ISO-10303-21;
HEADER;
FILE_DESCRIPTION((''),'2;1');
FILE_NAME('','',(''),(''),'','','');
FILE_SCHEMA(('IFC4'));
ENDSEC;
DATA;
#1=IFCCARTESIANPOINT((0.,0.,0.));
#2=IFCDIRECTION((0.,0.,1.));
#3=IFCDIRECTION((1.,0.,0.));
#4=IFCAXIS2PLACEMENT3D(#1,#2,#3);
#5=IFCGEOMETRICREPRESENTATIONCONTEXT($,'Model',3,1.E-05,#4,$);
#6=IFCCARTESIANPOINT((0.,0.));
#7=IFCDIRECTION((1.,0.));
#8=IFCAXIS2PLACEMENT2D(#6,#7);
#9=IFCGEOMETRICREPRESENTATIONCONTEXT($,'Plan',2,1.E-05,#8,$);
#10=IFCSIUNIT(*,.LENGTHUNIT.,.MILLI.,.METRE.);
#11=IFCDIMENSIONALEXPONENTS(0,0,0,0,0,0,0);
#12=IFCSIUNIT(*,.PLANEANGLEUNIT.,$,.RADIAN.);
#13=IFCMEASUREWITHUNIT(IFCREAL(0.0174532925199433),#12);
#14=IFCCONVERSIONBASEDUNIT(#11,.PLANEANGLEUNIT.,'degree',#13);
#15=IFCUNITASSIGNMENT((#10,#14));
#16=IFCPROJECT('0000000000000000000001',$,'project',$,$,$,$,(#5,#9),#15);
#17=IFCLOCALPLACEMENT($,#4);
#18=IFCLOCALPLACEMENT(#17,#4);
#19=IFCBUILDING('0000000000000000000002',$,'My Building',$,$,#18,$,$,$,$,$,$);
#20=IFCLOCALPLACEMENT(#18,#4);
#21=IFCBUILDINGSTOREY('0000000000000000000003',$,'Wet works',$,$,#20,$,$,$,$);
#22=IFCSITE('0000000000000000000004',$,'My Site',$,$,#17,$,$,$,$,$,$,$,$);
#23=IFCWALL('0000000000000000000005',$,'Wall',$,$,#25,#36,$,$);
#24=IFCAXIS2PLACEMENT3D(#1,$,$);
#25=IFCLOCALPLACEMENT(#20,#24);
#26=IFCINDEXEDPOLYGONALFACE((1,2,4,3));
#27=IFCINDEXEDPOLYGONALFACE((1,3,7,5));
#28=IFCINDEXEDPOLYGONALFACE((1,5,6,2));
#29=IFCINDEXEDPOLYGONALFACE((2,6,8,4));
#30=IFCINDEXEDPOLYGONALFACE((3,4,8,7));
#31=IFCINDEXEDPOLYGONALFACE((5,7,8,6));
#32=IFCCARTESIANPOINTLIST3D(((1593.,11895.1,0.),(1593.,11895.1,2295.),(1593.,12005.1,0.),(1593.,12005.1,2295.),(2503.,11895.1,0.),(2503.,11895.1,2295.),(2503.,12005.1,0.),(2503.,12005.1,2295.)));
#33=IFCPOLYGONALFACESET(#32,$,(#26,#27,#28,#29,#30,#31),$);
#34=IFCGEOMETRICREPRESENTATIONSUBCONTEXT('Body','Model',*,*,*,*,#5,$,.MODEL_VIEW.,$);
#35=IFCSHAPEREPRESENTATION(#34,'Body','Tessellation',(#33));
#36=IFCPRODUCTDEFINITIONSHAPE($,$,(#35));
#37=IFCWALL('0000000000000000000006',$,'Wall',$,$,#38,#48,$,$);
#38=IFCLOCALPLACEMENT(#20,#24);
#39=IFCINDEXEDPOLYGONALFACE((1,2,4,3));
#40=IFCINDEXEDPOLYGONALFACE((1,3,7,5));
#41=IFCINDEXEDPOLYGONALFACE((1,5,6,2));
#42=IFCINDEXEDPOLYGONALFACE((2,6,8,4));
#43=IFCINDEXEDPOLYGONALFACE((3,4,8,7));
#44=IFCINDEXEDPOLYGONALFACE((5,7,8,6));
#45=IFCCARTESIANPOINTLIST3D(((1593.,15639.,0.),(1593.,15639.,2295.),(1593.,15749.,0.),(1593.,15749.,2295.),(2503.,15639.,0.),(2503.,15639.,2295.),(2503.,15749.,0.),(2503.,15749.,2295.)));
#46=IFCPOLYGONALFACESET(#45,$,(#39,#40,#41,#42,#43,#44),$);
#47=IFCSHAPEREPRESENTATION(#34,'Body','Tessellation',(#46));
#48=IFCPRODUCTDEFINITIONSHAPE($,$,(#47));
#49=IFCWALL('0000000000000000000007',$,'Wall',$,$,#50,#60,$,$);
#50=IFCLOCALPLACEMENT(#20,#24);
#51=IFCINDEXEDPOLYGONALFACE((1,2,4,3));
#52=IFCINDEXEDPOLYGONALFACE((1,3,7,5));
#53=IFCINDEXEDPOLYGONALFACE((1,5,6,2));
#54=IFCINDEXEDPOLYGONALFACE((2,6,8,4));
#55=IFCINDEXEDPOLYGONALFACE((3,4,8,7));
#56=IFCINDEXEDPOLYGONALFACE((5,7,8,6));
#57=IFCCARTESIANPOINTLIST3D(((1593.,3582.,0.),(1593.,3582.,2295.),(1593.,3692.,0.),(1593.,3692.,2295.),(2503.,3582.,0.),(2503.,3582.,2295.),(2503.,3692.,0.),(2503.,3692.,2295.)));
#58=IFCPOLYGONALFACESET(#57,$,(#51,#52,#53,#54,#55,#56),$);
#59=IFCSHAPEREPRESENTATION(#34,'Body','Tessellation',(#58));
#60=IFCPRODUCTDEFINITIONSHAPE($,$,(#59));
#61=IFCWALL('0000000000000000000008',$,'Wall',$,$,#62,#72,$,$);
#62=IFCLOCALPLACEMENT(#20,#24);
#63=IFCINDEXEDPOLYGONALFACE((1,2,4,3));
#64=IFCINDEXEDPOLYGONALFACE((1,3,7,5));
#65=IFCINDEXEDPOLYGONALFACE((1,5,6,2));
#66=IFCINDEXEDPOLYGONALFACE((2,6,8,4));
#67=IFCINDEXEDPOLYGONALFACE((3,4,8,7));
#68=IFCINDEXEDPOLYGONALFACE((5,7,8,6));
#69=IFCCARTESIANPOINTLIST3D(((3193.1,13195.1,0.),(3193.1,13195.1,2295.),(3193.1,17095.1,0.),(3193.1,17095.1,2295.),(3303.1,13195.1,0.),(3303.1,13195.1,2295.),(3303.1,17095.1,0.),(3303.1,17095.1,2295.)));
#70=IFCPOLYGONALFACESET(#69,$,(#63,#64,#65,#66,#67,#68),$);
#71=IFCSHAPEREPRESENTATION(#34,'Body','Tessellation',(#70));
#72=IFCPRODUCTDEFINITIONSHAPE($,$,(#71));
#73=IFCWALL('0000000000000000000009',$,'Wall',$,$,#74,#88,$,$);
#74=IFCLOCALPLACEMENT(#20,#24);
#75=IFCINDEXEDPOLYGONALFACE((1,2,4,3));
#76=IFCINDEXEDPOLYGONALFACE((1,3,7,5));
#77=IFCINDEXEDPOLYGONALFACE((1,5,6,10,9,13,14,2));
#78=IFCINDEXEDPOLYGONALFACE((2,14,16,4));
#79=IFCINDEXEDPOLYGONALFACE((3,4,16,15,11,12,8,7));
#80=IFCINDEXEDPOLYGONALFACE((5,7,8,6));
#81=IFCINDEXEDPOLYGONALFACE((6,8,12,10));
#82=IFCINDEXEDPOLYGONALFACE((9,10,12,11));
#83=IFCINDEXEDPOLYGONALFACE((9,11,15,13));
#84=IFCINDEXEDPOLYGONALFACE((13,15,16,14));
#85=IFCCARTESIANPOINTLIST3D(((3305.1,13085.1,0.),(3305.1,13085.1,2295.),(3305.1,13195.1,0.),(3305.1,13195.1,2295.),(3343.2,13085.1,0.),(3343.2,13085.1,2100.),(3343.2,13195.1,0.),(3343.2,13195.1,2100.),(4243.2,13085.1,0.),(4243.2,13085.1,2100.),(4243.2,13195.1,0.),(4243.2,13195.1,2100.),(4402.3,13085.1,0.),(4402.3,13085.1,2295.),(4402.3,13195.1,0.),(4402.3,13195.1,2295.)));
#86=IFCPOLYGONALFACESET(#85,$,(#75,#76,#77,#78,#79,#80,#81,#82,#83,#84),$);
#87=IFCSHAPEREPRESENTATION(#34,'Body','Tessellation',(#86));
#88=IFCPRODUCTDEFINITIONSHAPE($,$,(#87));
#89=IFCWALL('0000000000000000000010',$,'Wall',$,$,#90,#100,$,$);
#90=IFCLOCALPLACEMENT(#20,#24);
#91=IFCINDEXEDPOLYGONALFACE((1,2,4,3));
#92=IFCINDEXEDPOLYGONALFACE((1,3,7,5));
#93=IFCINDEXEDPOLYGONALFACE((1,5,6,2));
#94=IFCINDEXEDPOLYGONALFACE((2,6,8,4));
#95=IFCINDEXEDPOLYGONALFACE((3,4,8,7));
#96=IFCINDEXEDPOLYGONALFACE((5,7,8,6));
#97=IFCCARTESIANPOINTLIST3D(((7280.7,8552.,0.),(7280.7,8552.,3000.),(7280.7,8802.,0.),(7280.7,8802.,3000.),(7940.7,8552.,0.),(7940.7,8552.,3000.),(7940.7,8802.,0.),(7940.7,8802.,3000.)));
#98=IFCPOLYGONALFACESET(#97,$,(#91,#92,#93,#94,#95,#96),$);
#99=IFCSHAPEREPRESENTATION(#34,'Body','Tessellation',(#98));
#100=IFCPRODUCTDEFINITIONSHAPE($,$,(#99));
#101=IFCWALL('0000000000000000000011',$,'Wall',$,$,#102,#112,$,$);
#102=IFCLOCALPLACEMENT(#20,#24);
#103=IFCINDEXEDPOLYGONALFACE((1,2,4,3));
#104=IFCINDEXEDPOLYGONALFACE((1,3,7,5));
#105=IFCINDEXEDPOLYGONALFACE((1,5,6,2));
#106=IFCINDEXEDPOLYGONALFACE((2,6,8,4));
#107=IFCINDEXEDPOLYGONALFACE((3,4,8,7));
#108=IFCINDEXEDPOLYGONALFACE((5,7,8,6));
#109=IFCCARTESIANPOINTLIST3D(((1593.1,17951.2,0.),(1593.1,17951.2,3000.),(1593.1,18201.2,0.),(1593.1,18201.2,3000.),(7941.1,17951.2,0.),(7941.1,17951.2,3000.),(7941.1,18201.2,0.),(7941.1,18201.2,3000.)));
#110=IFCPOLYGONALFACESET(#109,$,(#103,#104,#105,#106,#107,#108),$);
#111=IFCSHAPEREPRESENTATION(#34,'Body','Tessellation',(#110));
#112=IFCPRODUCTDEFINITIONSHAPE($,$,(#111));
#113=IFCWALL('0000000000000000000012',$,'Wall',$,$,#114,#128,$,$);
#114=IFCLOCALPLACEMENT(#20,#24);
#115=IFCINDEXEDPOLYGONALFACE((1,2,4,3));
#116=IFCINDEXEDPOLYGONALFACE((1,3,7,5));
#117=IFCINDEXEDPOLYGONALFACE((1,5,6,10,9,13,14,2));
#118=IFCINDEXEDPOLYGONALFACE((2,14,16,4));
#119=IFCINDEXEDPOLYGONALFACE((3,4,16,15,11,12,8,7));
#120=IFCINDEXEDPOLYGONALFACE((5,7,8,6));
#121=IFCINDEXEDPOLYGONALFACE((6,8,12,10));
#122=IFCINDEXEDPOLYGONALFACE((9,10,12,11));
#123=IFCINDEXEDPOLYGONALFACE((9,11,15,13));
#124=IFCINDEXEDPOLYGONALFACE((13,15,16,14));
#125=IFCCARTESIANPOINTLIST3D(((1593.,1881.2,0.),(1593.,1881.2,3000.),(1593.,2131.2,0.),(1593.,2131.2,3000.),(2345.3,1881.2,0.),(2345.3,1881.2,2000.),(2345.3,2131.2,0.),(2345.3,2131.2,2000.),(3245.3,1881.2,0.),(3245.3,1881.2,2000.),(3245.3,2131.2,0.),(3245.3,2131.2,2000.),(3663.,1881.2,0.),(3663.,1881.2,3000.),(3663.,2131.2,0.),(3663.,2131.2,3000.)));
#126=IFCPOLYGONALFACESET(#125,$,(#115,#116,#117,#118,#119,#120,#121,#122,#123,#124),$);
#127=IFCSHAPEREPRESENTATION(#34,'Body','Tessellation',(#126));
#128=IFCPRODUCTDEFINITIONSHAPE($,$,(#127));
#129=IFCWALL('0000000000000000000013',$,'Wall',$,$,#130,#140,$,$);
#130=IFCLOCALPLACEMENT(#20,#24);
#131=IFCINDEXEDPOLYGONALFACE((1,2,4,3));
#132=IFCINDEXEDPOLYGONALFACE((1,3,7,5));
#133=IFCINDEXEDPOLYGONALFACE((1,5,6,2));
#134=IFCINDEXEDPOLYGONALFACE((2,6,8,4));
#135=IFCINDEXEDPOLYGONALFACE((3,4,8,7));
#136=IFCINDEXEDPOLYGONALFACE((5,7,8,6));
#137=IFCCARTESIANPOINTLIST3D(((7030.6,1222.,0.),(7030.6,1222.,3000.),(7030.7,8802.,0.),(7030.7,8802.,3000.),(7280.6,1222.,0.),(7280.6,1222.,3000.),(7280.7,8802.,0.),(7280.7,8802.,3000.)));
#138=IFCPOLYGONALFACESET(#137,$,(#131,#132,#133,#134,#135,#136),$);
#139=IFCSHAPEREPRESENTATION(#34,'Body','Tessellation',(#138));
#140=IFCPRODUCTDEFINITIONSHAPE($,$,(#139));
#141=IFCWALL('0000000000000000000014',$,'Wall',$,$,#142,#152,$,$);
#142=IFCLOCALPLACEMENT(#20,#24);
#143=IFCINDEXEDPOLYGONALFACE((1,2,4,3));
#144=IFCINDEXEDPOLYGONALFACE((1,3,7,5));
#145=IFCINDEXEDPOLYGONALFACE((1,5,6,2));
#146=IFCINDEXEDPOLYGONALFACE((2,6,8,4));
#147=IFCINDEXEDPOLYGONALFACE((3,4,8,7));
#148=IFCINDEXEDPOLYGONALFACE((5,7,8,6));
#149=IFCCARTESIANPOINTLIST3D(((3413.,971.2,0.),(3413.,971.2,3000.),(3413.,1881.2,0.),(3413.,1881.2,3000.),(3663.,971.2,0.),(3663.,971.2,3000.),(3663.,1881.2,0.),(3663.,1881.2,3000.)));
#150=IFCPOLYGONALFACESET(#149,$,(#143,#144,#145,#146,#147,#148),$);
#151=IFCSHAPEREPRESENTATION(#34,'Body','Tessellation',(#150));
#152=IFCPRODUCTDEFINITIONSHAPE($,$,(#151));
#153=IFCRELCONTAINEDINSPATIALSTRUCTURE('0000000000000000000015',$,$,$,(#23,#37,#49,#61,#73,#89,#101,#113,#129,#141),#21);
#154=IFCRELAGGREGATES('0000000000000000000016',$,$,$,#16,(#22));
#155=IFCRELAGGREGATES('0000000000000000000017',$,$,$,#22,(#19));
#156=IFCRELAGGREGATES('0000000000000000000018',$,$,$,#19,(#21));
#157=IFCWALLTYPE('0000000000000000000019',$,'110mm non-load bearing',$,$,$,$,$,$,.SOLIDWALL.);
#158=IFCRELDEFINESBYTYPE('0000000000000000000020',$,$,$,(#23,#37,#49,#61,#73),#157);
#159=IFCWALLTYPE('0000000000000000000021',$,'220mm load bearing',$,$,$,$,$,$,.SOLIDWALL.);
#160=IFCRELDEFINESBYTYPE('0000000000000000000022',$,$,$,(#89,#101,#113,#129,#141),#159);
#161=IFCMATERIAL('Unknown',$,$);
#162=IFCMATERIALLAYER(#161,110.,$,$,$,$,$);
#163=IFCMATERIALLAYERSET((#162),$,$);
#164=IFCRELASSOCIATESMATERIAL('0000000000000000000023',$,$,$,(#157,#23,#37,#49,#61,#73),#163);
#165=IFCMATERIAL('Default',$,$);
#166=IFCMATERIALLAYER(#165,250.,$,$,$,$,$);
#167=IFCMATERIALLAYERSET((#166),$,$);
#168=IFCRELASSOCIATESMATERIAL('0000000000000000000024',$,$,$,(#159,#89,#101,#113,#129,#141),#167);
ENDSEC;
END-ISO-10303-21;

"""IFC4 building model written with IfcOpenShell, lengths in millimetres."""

from ifc_helpers import new_model, entity, si_unit, converted_unit, frame, origin_with_axes, origin_2d_with_axis, place, context, subcontext, project, spatial, line, indexed_curve, outline, extrude, source, transform, mapped, material, layer, layer_set, layer_usage, type_object, element, save


model = new_model("IFC4")

# Units and contexts
model_context = context("Model", 3, precision=1e-05, world=origin_with_axes())
plan_context = context("Plan", 2, precision=1e-05, world=origin_2d_with_axis())
body_context_1 = subcontext(model_context, "Body", "Model", "MODEL_VIEW")
ifc_project = project(units=[si_unit("LENGTHUNIT", "METRE", prefix="MILLI"), converted_unit("PLANEANGLEUNIT", "degree", entity("IfcReal", 0.0174532925199433), si_unit("PLANEANGLEUNIT", "RADIAN"), dimensions=[0, 0, 0, 0, 0, 0, 0])], contexts=[model_context, plan_context])

# Site, building, storey
site_placement = place(None, origin_with_axes())
site = spatial("IfcSite", under=ifc_project, at=site_placement, Name="My Site")
building_placement = place(site_placement, origin_with_axes())
building = spatial("IfcBuilding", under=site, at=building_placement, Name="My Building")
storey_placement = place(building_placement, origin_with_axes())
storey = spatial("IfcBuildingStorey", under=building, at=storey_placement, Name="Wet works")

# Shared definitions
ifc_material_1 = material(Name="Unknown")
ifc_layer_1 = layer(ifc_material_1, 110.0)
ifc_layer_set_1 = layer_set([ifc_layer_1])
wall_type_1 = type_object("IfcWallType", Name="110mm non-load bearing", PredefinedType="SOLIDWALL", material=ifc_layer_set_1)

# Shared definitions
shared_shape_1 = source(origin_with_axes(), body_context_1, "Body", "SweptSolid", [
    extrude(outline(indexed_curve([(0.0, 0.0), (900.0, 0.0), (900.0, 2100.0), (0.0, 2100.0)], segments=[line(1, 2, 3, 4, 1)])), frame((0.0, -600.0, 0.0), z_axis=(0.0, -1.0, 0.0), x_axis=(1.0, 0.0, 0.0)), (0.0, 0.0, -1.0), 1200.0),
])

# Walls
ifc_layer_usage_1 = layer_usage(ifc_layer_set_1, "AXIS2", "POSITIVE", 0.0)
wall_1_placement = place(storey_placement, frame((1593.0, 11895.1, 0.0), z_axis=(0.0, 0.0, 1.0), x_axis=(1.0, 0.0, 0.0)))
element("IfcWall", 1, at=wall_1_placement, inside=storey, type_object=wall_type_1, material=ifc_layer_usage_1, Name="Wall", context=body_context_1, shape_type="SweptSolid", body=[
    extrude(outline(indexed_curve([(0.0, 0.0), (0.0, 110.0), (910.0, 110.0), (910.0, 0.0), (0.0, 0.0)], self_intersect=False)), origin_with_axes(), (0.0, 0.0, 1.0), 2295.0),
])
ifc_layer_usage_2 = layer_usage(ifc_layer_set_1, "AXIS2", "POSITIVE", 0.0)
wall_2_placement = place(storey_placement, frame((1593.0, 15639.0, 0.0), z_axis=(0.0, 0.0, 1.0), x_axis=(1.0, 0.0, 0.0)))
element("IfcWall", 2, at=wall_2_placement, inside=storey, type_object=wall_type_1, material=ifc_layer_usage_2, Name="Wall", context=body_context_1, shape_type="SweptSolid", body=[
    extrude(outline(indexed_curve([(0.0, 0.0), (0.0, 110.0), (910.0, 110.0), (910.0, 0.0), (0.0, 0.0)], self_intersect=False)), origin_with_axes(), (0.0, 0.0, 1.0), 2295.0),
])
ifc_layer_usage_3 = layer_usage(ifc_layer_set_1, "AXIS2", "POSITIVE", 0.0)
wall_3_placement = place(storey_placement, frame((1593.0, 3582.0, 0.0), z_axis=(0.0, 0.0, 1.0), x_axis=(1.0, 0.0, 0.0)))
element("IfcWall", 3, at=wall_3_placement, inside=storey, type_object=wall_type_1, material=ifc_layer_usage_3, Name="Wall", context=body_context_1, shape_type="SweptSolid", body=[
    extrude(outline(indexed_curve([(0.0, 0.0), (0.0, 110.0), (910.0, 110.0), (910.0, 0.0), (0.0, 0.0)], self_intersect=False)), origin_with_axes(), (0.0, 0.0, 1.0), 2295.0),
])
ifc_layer_usage_4 = layer_usage(ifc_layer_set_1, "AXIS2", "POSITIVE", 0.0)
wall_4_placement = place(storey_placement, frame((3303.1, 13195.1, 0.0), z_axis=(0.0, 0.0, 1.0), x_axis=(0.0, 1.0, 0.0)))
element("IfcWall", 4, at=wall_4_placement, inside=storey, type_object=wall_type_1, material=ifc_layer_usage_4, Name="Wall", context=body_context_1, shape_type="SweptSolid", body=[
    extrude(outline(indexed_curve([(0.0, 0.0), (0.0, 110.0), (3900.0, 110.0), (3900.0, 0.0), (0.0, 0.0)], self_intersect=False)), origin_with_axes(), (0.0, 0.0, 1.0), 2295.0),
])

# Wall, opening
ifc_layer_usage_5 = layer_usage(ifc_layer_set_1, "AXIS2", "POSITIVE", 0.0)
wall_5_placement = place(storey_placement, frame((3305.1, 13085.1, 0.0), z_axis=(0.0, 0.0, 1.0), x_axis=(1.0, 0.0, 0.0)))
wall_5 = element("IfcWall", 5, at=wall_5_placement, inside=storey, type_object=wall_type_1, material=ifc_layer_usage_5, Name="Wall", context=body_context_1, shape_type="SweptSolid", body=[
    extrude(outline(indexed_curve([(0.0, 0.0), (0.0, 110.0), (1097.3, 110.0), (1097.3, 0.0), (0.0, 0.0)], self_intersect=False)), origin_with_axes(), (0.0, 0.0, 1.0), 2295.0),
])
opening_1_placement = place(wall_5_placement, frame((38.2, 0.0, 0.0), z_axis=(0.0, 0.0, 1.0), x_axis=(1.0, 0.0, 0.0)))
element("IfcOpeningElement", 6, at=opening_1_placement, cuts=wall_5, PredefinedType="OPENING", context=body_context_1, shape_type="MappedRepresentation", body=[
    mapped(shared_shape_1, transform((0.0, 0.0, 0.0), x_axis=(1.0, 0.0, 0.0), y_axis=(0.0, 1.0, 0.0), z_axis=(0.0, 0.0, 1.0), scale=1.0)),
])

# Walls
ifc_material_2 = material(Name="Default")
ifc_layer_2 = layer(ifc_material_2, 250.0)
ifc_layer_set_2 = layer_set([ifc_layer_2])
ifc_layer_usage_6 = layer_usage(ifc_layer_set_2, "AXIS2", "POSITIVE", 0.0)
wall_type_2 = type_object("IfcWallType", Name="220mm load bearing", PredefinedType="SOLIDWALL", material=ifc_layer_set_2)
wall_6_placement = place(storey_placement, frame((7280.7, 8552.0, 0.0), z_axis=(0.0, 0.0, 1.0), x_axis=(1.0, 0.0, 0.0)))
element("IfcWall", 7, at=wall_6_placement, inside=storey, type_object=wall_type_2, material=ifc_layer_usage_6, Name="Wall", context=body_context_1, shape_type="SweptSolid", body=[
    extrude(outline(indexed_curve([(0.0, 0.0), (0.0, 250.0), (660.0, 250.0), (660.0, 0.0), (0.0, 0.0)], self_intersect=False)), origin_with_axes(), (0.0, 0.0, 1.0), 3000.0),
])
ifc_layer_usage_7 = layer_usage(ifc_layer_set_2, "AXIS2", "POSITIVE", 0.0)
wall_7_placement = place(storey_placement, frame((1593.1, 17951.2, 0.0), z_axis=(0.0, 0.0, 1.0), x_axis=(1.0, 0.0, 0.0)))
element("IfcWall", 8, at=wall_7_placement, inside=storey, type_object=wall_type_2, material=ifc_layer_usage_7, Name="Wall", context=body_context_1, shape_type="SweptSolid", body=[
    extrude(outline(indexed_curve([(0.0, 0.0), (0.0, 250.0), (6348.0, 250.0), (6348.0, 0.0), (0.0, 0.0)], self_intersect=False)), origin_with_axes(), (0.0, 0.0, 1.0), 3000.0),
])

# Wall, opening
ifc_layer_usage_8 = layer_usage(ifc_layer_set_2, "AXIS2", "POSITIVE", 0.0)
wall_8_placement = place(storey_placement, frame((1593.0, 1881.2, 0.0), z_axis=(0.0, 0.0, 1.0), x_axis=(1.0, 0.0, 0.0)))
wall_8 = element("IfcWall", 9, at=wall_8_placement, inside=storey, type_object=wall_type_2, material=ifc_layer_usage_8, Name="Wall", context=body_context_1, shape_type="SweptSolid", body=[
    extrude(outline(indexed_curve([(0.0, 0.0), (0.0, 250.0), (2070.0, 250.0), (2070.0, 0.0), (0.0, 0.0)], self_intersect=False)), origin_with_axes(), (0.0, 0.0, 1.0), 3000.0),
])
shared_shape_2 = source(origin_with_axes(), body_context_1, "Body", "SweptSolid", [
    extrude(outline(indexed_curve([(0.0, 0.0), (900.0, 0.0), (900.0, 2000.0), (0.0, 2000.0)], segments=[line(1, 2, 3, 4, 1)])), frame((0.0, -600.0, 0.0), z_axis=(0.0, -1.0, 0.0), x_axis=(1.0, 0.0, 0.0)), (0.0, 0.0, -1.0), 1200.0),
])
opening_2_placement = place(wall_8_placement, frame((752.2, 0.0, 0.0), z_axis=(0.0, 0.0, 1.0), x_axis=(1.0, 0.0, 0.0)))
element("IfcOpeningElement", 10, at=opening_2_placement, cuts=wall_8, PredefinedType="OPENING", context=body_context_1, shape_type="MappedRepresentation", body=[
    mapped(shared_shape_2, transform((0.0, 0.0, 0.0), x_axis=(1.0, 0.0, 0.0), y_axis=(0.0, 1.0, 0.0), z_axis=(0.0, 0.0, 1.0), scale=1.0)),
])

# Walls
ifc_layer_usage_9 = layer_usage(ifc_layer_set_2, "AXIS2", "POSITIVE", 0.0)
wall_9_placement = place(storey_placement, frame((7280.6, 1222.0, 0.0), z_axis=(0.0, 0.0, 1.0), x_axis=(0.0, 1.0, 0.0)))
element("IfcWall", 11, at=wall_9_placement, inside=storey, type_object=wall_type_2, material=ifc_layer_usage_9, Name="Wall", context=body_context_1, shape_type="SweptSolid", body=[
    extrude(outline(indexed_curve([(0.0, 0.0), (0.0, 250.0), (7580.0, 250.0), (7580.0, 0.0), (0.0, 0.0)], self_intersect=False)), origin_with_axes(), (0.0, 0.0, 1.0), 3000.0),
])
ifc_layer_usage_10 = layer_usage(ifc_layer_set_2, "AXIS2", "POSITIVE", 0.0)
wall_10_placement = place(storey_placement, frame((3663.0, 971.2, 0.0), z_axis=(0.0, 0.0, 1.0), x_axis=(0.0, 1.0, 0.0)))
element("IfcWall", 12, at=wall_10_placement, inside=storey, type_object=wall_type_2, material=ifc_layer_usage_10, Name="Wall", context=body_context_1, shape_type="SweptSolid", body=[
    extrude(outline(indexed_curve([(0.0, 0.0), (0.0, 250.0), (910.0, 250.0), (910.0, 0.0), (0.0, 0.0)], self_intersect=False)), origin_with_axes(), (0.0, 0.0, 1.0), 3000.0),
])

save(model, "model.ifc")
